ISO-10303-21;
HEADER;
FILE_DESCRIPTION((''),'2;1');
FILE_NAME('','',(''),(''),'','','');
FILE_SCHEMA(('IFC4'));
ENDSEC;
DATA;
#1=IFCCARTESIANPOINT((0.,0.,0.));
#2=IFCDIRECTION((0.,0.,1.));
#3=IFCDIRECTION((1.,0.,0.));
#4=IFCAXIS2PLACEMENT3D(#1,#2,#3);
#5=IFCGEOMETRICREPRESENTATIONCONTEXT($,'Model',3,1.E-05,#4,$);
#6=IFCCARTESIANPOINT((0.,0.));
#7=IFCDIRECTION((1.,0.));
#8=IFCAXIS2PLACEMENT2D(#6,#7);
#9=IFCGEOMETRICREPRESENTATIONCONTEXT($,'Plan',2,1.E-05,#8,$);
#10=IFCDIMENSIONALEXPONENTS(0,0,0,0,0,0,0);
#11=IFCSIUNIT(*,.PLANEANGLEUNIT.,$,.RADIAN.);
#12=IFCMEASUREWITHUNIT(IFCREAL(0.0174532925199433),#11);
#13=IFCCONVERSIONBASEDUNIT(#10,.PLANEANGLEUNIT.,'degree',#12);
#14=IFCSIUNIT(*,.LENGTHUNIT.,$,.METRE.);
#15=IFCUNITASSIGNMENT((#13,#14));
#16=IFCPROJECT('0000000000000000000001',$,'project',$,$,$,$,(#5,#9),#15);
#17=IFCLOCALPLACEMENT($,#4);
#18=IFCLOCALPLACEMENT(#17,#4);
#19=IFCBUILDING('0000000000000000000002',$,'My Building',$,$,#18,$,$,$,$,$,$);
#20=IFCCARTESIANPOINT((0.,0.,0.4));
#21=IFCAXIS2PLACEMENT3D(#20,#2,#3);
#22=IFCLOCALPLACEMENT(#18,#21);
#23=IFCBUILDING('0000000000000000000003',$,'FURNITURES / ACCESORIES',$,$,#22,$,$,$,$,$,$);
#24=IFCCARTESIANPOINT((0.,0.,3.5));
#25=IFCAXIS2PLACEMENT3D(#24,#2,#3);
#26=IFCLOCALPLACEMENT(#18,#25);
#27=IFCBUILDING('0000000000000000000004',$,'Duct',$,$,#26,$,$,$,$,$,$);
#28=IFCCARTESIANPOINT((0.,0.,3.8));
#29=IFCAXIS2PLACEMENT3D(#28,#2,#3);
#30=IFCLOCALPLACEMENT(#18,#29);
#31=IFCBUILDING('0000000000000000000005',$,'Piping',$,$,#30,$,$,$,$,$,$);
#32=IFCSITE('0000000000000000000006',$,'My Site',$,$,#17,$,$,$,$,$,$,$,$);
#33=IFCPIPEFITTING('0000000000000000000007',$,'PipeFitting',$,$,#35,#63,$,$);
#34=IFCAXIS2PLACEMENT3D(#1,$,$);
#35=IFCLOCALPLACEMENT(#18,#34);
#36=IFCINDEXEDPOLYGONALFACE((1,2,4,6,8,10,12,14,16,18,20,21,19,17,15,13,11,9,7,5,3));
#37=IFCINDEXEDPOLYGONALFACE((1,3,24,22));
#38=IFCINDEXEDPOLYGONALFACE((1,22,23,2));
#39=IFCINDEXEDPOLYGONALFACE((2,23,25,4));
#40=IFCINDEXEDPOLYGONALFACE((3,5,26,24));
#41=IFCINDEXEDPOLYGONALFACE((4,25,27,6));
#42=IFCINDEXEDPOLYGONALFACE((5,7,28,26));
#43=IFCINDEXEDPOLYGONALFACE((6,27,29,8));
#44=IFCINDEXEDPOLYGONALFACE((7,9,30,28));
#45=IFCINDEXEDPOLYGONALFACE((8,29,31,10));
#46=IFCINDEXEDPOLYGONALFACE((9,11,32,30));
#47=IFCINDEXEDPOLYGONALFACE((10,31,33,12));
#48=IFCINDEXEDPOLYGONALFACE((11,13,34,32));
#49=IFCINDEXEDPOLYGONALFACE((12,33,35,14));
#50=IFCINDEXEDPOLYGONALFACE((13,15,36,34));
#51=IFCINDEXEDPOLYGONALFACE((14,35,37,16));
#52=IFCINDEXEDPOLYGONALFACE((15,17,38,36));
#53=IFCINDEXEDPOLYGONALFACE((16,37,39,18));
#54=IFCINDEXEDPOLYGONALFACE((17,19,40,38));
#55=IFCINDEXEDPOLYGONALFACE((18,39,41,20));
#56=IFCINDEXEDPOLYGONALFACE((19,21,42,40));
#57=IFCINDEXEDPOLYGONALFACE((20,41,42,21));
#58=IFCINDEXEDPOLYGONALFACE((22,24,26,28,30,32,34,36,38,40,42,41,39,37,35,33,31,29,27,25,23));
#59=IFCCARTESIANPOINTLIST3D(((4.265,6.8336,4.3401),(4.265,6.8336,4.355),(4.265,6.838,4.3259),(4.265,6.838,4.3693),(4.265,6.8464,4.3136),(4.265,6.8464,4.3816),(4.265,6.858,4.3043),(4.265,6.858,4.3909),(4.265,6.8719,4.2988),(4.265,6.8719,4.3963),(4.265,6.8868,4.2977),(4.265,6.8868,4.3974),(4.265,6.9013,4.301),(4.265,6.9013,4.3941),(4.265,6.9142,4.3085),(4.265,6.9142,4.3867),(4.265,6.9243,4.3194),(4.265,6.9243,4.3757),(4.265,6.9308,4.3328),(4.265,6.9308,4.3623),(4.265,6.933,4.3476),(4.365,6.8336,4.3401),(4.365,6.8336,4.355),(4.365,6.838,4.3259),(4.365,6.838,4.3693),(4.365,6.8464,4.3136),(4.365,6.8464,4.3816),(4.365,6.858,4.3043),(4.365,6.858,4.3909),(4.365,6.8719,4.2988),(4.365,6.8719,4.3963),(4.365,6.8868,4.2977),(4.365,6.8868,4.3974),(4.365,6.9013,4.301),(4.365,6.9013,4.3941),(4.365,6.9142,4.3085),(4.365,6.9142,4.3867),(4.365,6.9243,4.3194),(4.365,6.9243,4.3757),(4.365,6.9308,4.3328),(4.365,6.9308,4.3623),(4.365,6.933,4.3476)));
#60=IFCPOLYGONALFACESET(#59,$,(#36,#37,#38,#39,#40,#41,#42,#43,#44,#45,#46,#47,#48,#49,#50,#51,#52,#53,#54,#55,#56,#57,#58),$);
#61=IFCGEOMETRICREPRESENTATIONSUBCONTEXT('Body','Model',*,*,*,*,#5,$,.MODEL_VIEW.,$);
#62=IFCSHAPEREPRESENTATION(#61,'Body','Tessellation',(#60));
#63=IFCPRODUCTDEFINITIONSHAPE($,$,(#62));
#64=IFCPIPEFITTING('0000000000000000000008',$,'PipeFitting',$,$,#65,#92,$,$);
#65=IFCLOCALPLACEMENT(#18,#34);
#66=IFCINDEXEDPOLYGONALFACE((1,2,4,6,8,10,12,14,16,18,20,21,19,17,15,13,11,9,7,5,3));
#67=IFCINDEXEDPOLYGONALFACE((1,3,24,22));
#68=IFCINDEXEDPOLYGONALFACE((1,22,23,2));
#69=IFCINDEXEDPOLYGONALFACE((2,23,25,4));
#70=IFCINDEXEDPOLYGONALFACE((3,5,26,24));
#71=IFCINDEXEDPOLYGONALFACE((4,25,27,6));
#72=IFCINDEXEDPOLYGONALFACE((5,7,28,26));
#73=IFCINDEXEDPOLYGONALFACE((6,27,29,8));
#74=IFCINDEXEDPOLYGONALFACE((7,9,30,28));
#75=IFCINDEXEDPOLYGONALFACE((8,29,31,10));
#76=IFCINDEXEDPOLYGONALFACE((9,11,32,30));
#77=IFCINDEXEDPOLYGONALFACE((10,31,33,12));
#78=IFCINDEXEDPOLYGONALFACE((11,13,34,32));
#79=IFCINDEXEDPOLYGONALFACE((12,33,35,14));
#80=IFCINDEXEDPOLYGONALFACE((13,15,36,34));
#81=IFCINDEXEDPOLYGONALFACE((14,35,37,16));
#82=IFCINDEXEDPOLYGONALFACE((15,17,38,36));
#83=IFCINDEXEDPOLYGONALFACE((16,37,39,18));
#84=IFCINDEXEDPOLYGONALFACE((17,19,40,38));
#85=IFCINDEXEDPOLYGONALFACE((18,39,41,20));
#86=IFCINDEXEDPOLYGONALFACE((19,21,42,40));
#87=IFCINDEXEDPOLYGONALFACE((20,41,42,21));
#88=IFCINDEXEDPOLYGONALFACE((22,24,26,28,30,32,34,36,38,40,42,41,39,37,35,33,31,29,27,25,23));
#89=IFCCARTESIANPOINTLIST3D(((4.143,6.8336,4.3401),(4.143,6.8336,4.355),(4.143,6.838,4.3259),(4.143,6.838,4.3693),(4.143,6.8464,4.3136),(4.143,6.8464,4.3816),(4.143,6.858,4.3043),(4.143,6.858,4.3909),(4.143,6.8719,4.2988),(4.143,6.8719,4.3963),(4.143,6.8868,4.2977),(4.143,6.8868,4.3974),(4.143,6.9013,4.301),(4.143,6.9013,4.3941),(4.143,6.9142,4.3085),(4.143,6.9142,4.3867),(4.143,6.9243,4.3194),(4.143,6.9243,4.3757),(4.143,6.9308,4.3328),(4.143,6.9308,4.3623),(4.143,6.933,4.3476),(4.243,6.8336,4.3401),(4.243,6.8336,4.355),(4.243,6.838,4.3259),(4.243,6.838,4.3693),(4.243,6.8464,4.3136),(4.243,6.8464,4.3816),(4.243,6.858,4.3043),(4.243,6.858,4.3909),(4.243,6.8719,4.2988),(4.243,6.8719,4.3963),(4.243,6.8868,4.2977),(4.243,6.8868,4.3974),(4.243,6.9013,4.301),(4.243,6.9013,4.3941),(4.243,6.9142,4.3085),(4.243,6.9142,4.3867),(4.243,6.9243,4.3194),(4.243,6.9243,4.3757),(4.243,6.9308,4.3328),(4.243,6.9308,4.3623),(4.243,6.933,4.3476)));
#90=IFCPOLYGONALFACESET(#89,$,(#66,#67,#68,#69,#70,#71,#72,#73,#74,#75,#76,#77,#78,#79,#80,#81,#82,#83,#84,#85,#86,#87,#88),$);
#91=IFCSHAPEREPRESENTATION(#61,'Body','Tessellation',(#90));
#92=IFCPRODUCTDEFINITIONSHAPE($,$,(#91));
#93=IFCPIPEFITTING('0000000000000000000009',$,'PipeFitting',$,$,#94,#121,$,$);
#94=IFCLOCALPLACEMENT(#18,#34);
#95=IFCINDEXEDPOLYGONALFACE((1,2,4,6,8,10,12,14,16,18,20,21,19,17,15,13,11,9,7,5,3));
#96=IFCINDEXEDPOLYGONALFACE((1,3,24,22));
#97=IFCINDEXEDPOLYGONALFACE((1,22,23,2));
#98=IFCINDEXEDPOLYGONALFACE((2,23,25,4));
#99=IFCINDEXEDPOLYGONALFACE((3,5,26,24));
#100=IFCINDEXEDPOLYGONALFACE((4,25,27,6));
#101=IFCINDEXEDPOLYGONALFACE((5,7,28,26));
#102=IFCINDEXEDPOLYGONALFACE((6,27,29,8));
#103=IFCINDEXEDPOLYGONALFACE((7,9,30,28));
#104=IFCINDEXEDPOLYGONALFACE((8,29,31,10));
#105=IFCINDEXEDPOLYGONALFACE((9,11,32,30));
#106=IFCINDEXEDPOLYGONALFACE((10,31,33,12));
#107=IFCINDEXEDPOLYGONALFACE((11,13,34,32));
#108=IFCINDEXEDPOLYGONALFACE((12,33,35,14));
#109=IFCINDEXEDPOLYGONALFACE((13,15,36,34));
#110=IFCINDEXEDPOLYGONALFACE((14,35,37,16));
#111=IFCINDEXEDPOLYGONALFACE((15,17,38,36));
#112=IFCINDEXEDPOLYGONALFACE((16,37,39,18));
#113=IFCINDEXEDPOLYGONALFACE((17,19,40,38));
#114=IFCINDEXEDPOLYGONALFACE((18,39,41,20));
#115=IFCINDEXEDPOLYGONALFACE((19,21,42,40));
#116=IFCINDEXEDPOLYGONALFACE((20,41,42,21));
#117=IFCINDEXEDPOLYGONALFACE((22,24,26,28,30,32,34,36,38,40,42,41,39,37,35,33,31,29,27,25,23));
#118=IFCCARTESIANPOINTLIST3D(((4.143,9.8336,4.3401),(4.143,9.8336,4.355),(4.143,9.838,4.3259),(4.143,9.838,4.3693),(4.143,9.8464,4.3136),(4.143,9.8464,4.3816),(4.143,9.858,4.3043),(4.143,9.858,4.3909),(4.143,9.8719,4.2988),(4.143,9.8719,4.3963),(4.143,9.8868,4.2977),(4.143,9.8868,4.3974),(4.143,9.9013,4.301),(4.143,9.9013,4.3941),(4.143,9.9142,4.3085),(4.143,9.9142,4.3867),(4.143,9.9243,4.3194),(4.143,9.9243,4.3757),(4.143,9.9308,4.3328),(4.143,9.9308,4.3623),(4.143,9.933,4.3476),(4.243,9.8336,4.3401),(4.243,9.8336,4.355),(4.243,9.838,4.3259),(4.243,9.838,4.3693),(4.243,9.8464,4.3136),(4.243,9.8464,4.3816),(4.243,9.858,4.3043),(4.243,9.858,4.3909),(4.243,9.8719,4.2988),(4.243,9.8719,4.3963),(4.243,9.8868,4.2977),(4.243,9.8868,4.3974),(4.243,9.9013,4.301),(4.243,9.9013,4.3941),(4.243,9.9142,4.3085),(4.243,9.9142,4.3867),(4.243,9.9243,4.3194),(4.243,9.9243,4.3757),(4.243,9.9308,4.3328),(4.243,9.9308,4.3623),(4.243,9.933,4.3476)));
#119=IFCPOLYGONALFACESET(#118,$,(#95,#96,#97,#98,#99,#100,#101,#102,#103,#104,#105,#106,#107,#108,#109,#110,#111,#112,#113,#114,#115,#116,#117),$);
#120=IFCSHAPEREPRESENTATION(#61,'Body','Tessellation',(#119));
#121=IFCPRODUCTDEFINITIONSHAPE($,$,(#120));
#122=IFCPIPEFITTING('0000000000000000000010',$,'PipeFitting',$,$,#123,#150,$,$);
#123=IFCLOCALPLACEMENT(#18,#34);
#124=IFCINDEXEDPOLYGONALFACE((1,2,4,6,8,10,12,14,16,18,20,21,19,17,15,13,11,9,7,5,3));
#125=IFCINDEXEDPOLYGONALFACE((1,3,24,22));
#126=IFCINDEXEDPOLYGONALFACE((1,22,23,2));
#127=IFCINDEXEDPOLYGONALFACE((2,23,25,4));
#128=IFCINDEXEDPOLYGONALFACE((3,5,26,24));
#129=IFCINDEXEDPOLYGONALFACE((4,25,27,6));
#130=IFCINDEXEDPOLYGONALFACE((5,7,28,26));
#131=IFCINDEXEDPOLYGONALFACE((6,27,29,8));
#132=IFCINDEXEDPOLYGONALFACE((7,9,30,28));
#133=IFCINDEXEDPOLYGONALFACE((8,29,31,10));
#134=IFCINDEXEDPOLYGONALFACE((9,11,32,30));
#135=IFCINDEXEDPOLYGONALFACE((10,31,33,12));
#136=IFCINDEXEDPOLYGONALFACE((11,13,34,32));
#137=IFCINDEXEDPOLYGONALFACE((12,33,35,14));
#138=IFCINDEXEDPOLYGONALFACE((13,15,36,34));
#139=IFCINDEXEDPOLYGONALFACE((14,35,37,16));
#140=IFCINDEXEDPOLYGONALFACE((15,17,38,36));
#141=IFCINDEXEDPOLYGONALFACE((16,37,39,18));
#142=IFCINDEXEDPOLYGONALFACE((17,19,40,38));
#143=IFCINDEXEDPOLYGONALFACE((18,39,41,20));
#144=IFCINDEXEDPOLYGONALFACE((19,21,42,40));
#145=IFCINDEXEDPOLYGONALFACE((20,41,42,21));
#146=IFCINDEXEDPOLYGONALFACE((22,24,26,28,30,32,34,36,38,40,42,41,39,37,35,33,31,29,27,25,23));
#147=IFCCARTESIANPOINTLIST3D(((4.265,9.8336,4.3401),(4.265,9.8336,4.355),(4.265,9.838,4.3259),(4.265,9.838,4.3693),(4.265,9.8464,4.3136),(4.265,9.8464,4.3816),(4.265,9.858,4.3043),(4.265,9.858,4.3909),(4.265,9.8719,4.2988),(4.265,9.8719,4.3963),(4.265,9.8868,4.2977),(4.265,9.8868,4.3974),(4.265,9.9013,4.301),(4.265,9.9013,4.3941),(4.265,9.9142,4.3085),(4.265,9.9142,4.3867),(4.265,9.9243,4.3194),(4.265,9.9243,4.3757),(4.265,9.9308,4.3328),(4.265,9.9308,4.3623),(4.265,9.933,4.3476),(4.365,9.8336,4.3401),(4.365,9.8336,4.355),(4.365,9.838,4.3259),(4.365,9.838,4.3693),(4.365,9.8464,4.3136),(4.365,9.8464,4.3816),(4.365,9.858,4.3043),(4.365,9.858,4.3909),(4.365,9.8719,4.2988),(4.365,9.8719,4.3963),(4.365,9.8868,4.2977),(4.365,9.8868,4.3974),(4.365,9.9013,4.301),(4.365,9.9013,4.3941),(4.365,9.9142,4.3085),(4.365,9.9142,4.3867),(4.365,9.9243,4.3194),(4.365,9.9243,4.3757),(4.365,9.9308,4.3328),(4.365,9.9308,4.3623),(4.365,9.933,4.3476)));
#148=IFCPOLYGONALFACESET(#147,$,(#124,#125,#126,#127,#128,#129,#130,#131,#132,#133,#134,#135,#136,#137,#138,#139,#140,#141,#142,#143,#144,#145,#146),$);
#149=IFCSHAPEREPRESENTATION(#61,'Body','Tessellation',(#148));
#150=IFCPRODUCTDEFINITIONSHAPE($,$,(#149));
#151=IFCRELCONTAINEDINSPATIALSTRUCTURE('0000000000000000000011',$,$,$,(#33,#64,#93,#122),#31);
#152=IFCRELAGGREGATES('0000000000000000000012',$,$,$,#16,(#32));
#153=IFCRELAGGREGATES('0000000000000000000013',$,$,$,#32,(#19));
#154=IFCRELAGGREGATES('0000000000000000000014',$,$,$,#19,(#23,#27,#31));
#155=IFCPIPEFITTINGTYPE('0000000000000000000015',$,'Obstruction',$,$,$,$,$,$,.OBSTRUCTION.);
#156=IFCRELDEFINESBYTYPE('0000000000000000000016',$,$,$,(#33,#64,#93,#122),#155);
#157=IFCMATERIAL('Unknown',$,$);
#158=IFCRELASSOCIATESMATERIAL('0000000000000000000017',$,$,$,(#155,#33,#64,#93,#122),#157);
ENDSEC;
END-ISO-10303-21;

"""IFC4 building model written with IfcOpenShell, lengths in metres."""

from ifc_helpers import new_model, entity, si_unit, converted_unit, frame, origin_with_axes, origin_2d_with_axis, place, context, subcontext, project, spatial, circle, extrude, material, material_profile, profile_set, profile_usage, type_object, element, save


model = new_model("IFC4")

# Units and contexts
model_context = context("Model", 3, precision=1e-05, world=origin_with_axes())
plan_context = context("Plan", 2, precision=1e-05, world=origin_2d_with_axis())
body_context = subcontext(model_context, "Body", "Model", "MODEL_VIEW")
ifc_project = project(units=[converted_unit("PLANEANGLEUNIT", "degree", entity("IfcReal", 0.0174532925199433), si_unit("PLANEANGLEUNIT", "RADIAN"), dimensions=[0, 0, 0, 0, 0, 0, 0]), si_unit("LENGTHUNIT", "METRE")], contexts=[model_context, plan_context])

# Site, building
site_placement = place(None, origin_with_axes())
site = spatial("IfcSite", under=ifc_project, at=site_placement, Name="My Site")
building_1_placement = place(site_placement, origin_with_axes())
building_1 = spatial("IfcBuilding", under=site, at=building_1_placement, Name="My Building")

# Shared definitions
ifc_material = material(Name="Unknown")

# Shared definitions
building_2_placement = place(building_1_placement, frame((0.0, 0.0, 0.4), z_axis=(0.0, 0.0, 1.0), x_axis=(1.0, 0.0, 0.0)))
building_2 = spatial("IfcBuilding", under=building_1, at=building_2_placement, Name="FURNITURES / ACCESORIES")

# Shared definitions
building_3_placement = place(building_1_placement, frame((0.0, 0.0, 3.5), z_axis=(0.0, 0.0, 1.0), x_axis=(1.0, 0.0, 0.0)))
building_3 = spatial("IfcBuilding", under=building_1, at=building_3_placement, Name="Duct")

# Shared definitions
building_4_placement = place(building_1_placement, frame((0.0, 0.0, 3.8), z_axis=(0.0, 0.0, 1.0), x_axis=(1.0, 0.0, 0.0)))
building_4 = spatial("IfcBuilding", under=building_1, at=building_4_placement, Name="Piping")

# Pipe fittings
ifc_material_profile_1 = material_profile(ifc_material, circle(Radius=0.05))
ifc_profile_set_1 = profile_set([ifc_material_profile_1])
ifc_profile_usage_1 = profile_usage(ifc_profile_set_1, cardinal=5)
pipe_fitting_type_1 = type_object("IfcPipeFittingType", Name="Obstruction", PredefinedType="OBSTRUCTION", material=ifc_profile_set_1)
pipe_fitting_1_placement = place(building_4_placement, frame((4.265, 6.883, 0.5476), z_axis=(1.0, -0.000001, 0.000001), x_axis=(0.000001, 1.0, 0.0)))
element("IfcPipeFitting", 1, at=pipe_fitting_1_placement, inside=building_4, type_object=pipe_fitting_type_1, material=ifc_profile_usage_1, Name="PipeFitting", context=body_context, shape_type="SweptSolid", body=[
    extrude(circle(Radius=0.05), origin_with_axes(), (0.0, 0.0, 1.0), 0.1),
])
ifc_profile_usage_2 = profile_usage(ifc_profile_set_1, cardinal=5)
pipe_fitting_2_placement = place(building_4_placement, frame((4.243, 6.883, 0.5476), z_axis=(-1.0, -0.000001, -0.000001), x_axis=(-0.000001, 1.0, 0.0)))
element("IfcPipeFitting", 2, at=pipe_fitting_2_placement, inside=building_4, type_object=pipe_fitting_type_1, material=ifc_profile_usage_2, Name="PipeFitting", context=body_context, shape_type="SweptSolid", body=[
    extrude(circle(Radius=0.05), origin_with_axes(), (0.0, 0.0, 1.0), 0.1),
])
ifc_profile_usage_3 = profile_usage(ifc_profile_set_1, cardinal=5)
pipe_fitting_3_placement = place(building_4_placement, frame((4.243, 9.883, 0.5476), z_axis=(-1.0, -0.000001, -0.000001), x_axis=(-0.000001, 1.0, 0.0)))
element("IfcPipeFitting", 3, at=pipe_fitting_3_placement, inside=building_4, type_object=pipe_fitting_type_1, material=ifc_profile_usage_3, Name="PipeFitting", context=body_context, shape_type="SweptSolid", body=[
    extrude(circle(Radius=0.05), origin_with_axes(), (0.0, 0.0, 1.0), 0.1),
])
ifc_profile_usage_4 = profile_usage(ifc_profile_set_1, cardinal=5)
pipe_fitting_4_placement = place(building_4_placement, frame((4.265, 9.883, 0.5476), z_axis=(1.0, -0.000001, 0.000001), x_axis=(0.000001, 1.0, 0.0)))
element("IfcPipeFitting", 4, at=pipe_fitting_4_placement, inside=building_4, type_object=pipe_fitting_type_1, material=ifc_profile_usage_4, Name="PipeFitting", context=body_context, shape_type="SweptSolid", body=[
    extrude(circle(Radius=0.05), origin_with_axes(), (0.0, 0.0, 1.0), 0.1),
])

save(model, "model.ifc")
